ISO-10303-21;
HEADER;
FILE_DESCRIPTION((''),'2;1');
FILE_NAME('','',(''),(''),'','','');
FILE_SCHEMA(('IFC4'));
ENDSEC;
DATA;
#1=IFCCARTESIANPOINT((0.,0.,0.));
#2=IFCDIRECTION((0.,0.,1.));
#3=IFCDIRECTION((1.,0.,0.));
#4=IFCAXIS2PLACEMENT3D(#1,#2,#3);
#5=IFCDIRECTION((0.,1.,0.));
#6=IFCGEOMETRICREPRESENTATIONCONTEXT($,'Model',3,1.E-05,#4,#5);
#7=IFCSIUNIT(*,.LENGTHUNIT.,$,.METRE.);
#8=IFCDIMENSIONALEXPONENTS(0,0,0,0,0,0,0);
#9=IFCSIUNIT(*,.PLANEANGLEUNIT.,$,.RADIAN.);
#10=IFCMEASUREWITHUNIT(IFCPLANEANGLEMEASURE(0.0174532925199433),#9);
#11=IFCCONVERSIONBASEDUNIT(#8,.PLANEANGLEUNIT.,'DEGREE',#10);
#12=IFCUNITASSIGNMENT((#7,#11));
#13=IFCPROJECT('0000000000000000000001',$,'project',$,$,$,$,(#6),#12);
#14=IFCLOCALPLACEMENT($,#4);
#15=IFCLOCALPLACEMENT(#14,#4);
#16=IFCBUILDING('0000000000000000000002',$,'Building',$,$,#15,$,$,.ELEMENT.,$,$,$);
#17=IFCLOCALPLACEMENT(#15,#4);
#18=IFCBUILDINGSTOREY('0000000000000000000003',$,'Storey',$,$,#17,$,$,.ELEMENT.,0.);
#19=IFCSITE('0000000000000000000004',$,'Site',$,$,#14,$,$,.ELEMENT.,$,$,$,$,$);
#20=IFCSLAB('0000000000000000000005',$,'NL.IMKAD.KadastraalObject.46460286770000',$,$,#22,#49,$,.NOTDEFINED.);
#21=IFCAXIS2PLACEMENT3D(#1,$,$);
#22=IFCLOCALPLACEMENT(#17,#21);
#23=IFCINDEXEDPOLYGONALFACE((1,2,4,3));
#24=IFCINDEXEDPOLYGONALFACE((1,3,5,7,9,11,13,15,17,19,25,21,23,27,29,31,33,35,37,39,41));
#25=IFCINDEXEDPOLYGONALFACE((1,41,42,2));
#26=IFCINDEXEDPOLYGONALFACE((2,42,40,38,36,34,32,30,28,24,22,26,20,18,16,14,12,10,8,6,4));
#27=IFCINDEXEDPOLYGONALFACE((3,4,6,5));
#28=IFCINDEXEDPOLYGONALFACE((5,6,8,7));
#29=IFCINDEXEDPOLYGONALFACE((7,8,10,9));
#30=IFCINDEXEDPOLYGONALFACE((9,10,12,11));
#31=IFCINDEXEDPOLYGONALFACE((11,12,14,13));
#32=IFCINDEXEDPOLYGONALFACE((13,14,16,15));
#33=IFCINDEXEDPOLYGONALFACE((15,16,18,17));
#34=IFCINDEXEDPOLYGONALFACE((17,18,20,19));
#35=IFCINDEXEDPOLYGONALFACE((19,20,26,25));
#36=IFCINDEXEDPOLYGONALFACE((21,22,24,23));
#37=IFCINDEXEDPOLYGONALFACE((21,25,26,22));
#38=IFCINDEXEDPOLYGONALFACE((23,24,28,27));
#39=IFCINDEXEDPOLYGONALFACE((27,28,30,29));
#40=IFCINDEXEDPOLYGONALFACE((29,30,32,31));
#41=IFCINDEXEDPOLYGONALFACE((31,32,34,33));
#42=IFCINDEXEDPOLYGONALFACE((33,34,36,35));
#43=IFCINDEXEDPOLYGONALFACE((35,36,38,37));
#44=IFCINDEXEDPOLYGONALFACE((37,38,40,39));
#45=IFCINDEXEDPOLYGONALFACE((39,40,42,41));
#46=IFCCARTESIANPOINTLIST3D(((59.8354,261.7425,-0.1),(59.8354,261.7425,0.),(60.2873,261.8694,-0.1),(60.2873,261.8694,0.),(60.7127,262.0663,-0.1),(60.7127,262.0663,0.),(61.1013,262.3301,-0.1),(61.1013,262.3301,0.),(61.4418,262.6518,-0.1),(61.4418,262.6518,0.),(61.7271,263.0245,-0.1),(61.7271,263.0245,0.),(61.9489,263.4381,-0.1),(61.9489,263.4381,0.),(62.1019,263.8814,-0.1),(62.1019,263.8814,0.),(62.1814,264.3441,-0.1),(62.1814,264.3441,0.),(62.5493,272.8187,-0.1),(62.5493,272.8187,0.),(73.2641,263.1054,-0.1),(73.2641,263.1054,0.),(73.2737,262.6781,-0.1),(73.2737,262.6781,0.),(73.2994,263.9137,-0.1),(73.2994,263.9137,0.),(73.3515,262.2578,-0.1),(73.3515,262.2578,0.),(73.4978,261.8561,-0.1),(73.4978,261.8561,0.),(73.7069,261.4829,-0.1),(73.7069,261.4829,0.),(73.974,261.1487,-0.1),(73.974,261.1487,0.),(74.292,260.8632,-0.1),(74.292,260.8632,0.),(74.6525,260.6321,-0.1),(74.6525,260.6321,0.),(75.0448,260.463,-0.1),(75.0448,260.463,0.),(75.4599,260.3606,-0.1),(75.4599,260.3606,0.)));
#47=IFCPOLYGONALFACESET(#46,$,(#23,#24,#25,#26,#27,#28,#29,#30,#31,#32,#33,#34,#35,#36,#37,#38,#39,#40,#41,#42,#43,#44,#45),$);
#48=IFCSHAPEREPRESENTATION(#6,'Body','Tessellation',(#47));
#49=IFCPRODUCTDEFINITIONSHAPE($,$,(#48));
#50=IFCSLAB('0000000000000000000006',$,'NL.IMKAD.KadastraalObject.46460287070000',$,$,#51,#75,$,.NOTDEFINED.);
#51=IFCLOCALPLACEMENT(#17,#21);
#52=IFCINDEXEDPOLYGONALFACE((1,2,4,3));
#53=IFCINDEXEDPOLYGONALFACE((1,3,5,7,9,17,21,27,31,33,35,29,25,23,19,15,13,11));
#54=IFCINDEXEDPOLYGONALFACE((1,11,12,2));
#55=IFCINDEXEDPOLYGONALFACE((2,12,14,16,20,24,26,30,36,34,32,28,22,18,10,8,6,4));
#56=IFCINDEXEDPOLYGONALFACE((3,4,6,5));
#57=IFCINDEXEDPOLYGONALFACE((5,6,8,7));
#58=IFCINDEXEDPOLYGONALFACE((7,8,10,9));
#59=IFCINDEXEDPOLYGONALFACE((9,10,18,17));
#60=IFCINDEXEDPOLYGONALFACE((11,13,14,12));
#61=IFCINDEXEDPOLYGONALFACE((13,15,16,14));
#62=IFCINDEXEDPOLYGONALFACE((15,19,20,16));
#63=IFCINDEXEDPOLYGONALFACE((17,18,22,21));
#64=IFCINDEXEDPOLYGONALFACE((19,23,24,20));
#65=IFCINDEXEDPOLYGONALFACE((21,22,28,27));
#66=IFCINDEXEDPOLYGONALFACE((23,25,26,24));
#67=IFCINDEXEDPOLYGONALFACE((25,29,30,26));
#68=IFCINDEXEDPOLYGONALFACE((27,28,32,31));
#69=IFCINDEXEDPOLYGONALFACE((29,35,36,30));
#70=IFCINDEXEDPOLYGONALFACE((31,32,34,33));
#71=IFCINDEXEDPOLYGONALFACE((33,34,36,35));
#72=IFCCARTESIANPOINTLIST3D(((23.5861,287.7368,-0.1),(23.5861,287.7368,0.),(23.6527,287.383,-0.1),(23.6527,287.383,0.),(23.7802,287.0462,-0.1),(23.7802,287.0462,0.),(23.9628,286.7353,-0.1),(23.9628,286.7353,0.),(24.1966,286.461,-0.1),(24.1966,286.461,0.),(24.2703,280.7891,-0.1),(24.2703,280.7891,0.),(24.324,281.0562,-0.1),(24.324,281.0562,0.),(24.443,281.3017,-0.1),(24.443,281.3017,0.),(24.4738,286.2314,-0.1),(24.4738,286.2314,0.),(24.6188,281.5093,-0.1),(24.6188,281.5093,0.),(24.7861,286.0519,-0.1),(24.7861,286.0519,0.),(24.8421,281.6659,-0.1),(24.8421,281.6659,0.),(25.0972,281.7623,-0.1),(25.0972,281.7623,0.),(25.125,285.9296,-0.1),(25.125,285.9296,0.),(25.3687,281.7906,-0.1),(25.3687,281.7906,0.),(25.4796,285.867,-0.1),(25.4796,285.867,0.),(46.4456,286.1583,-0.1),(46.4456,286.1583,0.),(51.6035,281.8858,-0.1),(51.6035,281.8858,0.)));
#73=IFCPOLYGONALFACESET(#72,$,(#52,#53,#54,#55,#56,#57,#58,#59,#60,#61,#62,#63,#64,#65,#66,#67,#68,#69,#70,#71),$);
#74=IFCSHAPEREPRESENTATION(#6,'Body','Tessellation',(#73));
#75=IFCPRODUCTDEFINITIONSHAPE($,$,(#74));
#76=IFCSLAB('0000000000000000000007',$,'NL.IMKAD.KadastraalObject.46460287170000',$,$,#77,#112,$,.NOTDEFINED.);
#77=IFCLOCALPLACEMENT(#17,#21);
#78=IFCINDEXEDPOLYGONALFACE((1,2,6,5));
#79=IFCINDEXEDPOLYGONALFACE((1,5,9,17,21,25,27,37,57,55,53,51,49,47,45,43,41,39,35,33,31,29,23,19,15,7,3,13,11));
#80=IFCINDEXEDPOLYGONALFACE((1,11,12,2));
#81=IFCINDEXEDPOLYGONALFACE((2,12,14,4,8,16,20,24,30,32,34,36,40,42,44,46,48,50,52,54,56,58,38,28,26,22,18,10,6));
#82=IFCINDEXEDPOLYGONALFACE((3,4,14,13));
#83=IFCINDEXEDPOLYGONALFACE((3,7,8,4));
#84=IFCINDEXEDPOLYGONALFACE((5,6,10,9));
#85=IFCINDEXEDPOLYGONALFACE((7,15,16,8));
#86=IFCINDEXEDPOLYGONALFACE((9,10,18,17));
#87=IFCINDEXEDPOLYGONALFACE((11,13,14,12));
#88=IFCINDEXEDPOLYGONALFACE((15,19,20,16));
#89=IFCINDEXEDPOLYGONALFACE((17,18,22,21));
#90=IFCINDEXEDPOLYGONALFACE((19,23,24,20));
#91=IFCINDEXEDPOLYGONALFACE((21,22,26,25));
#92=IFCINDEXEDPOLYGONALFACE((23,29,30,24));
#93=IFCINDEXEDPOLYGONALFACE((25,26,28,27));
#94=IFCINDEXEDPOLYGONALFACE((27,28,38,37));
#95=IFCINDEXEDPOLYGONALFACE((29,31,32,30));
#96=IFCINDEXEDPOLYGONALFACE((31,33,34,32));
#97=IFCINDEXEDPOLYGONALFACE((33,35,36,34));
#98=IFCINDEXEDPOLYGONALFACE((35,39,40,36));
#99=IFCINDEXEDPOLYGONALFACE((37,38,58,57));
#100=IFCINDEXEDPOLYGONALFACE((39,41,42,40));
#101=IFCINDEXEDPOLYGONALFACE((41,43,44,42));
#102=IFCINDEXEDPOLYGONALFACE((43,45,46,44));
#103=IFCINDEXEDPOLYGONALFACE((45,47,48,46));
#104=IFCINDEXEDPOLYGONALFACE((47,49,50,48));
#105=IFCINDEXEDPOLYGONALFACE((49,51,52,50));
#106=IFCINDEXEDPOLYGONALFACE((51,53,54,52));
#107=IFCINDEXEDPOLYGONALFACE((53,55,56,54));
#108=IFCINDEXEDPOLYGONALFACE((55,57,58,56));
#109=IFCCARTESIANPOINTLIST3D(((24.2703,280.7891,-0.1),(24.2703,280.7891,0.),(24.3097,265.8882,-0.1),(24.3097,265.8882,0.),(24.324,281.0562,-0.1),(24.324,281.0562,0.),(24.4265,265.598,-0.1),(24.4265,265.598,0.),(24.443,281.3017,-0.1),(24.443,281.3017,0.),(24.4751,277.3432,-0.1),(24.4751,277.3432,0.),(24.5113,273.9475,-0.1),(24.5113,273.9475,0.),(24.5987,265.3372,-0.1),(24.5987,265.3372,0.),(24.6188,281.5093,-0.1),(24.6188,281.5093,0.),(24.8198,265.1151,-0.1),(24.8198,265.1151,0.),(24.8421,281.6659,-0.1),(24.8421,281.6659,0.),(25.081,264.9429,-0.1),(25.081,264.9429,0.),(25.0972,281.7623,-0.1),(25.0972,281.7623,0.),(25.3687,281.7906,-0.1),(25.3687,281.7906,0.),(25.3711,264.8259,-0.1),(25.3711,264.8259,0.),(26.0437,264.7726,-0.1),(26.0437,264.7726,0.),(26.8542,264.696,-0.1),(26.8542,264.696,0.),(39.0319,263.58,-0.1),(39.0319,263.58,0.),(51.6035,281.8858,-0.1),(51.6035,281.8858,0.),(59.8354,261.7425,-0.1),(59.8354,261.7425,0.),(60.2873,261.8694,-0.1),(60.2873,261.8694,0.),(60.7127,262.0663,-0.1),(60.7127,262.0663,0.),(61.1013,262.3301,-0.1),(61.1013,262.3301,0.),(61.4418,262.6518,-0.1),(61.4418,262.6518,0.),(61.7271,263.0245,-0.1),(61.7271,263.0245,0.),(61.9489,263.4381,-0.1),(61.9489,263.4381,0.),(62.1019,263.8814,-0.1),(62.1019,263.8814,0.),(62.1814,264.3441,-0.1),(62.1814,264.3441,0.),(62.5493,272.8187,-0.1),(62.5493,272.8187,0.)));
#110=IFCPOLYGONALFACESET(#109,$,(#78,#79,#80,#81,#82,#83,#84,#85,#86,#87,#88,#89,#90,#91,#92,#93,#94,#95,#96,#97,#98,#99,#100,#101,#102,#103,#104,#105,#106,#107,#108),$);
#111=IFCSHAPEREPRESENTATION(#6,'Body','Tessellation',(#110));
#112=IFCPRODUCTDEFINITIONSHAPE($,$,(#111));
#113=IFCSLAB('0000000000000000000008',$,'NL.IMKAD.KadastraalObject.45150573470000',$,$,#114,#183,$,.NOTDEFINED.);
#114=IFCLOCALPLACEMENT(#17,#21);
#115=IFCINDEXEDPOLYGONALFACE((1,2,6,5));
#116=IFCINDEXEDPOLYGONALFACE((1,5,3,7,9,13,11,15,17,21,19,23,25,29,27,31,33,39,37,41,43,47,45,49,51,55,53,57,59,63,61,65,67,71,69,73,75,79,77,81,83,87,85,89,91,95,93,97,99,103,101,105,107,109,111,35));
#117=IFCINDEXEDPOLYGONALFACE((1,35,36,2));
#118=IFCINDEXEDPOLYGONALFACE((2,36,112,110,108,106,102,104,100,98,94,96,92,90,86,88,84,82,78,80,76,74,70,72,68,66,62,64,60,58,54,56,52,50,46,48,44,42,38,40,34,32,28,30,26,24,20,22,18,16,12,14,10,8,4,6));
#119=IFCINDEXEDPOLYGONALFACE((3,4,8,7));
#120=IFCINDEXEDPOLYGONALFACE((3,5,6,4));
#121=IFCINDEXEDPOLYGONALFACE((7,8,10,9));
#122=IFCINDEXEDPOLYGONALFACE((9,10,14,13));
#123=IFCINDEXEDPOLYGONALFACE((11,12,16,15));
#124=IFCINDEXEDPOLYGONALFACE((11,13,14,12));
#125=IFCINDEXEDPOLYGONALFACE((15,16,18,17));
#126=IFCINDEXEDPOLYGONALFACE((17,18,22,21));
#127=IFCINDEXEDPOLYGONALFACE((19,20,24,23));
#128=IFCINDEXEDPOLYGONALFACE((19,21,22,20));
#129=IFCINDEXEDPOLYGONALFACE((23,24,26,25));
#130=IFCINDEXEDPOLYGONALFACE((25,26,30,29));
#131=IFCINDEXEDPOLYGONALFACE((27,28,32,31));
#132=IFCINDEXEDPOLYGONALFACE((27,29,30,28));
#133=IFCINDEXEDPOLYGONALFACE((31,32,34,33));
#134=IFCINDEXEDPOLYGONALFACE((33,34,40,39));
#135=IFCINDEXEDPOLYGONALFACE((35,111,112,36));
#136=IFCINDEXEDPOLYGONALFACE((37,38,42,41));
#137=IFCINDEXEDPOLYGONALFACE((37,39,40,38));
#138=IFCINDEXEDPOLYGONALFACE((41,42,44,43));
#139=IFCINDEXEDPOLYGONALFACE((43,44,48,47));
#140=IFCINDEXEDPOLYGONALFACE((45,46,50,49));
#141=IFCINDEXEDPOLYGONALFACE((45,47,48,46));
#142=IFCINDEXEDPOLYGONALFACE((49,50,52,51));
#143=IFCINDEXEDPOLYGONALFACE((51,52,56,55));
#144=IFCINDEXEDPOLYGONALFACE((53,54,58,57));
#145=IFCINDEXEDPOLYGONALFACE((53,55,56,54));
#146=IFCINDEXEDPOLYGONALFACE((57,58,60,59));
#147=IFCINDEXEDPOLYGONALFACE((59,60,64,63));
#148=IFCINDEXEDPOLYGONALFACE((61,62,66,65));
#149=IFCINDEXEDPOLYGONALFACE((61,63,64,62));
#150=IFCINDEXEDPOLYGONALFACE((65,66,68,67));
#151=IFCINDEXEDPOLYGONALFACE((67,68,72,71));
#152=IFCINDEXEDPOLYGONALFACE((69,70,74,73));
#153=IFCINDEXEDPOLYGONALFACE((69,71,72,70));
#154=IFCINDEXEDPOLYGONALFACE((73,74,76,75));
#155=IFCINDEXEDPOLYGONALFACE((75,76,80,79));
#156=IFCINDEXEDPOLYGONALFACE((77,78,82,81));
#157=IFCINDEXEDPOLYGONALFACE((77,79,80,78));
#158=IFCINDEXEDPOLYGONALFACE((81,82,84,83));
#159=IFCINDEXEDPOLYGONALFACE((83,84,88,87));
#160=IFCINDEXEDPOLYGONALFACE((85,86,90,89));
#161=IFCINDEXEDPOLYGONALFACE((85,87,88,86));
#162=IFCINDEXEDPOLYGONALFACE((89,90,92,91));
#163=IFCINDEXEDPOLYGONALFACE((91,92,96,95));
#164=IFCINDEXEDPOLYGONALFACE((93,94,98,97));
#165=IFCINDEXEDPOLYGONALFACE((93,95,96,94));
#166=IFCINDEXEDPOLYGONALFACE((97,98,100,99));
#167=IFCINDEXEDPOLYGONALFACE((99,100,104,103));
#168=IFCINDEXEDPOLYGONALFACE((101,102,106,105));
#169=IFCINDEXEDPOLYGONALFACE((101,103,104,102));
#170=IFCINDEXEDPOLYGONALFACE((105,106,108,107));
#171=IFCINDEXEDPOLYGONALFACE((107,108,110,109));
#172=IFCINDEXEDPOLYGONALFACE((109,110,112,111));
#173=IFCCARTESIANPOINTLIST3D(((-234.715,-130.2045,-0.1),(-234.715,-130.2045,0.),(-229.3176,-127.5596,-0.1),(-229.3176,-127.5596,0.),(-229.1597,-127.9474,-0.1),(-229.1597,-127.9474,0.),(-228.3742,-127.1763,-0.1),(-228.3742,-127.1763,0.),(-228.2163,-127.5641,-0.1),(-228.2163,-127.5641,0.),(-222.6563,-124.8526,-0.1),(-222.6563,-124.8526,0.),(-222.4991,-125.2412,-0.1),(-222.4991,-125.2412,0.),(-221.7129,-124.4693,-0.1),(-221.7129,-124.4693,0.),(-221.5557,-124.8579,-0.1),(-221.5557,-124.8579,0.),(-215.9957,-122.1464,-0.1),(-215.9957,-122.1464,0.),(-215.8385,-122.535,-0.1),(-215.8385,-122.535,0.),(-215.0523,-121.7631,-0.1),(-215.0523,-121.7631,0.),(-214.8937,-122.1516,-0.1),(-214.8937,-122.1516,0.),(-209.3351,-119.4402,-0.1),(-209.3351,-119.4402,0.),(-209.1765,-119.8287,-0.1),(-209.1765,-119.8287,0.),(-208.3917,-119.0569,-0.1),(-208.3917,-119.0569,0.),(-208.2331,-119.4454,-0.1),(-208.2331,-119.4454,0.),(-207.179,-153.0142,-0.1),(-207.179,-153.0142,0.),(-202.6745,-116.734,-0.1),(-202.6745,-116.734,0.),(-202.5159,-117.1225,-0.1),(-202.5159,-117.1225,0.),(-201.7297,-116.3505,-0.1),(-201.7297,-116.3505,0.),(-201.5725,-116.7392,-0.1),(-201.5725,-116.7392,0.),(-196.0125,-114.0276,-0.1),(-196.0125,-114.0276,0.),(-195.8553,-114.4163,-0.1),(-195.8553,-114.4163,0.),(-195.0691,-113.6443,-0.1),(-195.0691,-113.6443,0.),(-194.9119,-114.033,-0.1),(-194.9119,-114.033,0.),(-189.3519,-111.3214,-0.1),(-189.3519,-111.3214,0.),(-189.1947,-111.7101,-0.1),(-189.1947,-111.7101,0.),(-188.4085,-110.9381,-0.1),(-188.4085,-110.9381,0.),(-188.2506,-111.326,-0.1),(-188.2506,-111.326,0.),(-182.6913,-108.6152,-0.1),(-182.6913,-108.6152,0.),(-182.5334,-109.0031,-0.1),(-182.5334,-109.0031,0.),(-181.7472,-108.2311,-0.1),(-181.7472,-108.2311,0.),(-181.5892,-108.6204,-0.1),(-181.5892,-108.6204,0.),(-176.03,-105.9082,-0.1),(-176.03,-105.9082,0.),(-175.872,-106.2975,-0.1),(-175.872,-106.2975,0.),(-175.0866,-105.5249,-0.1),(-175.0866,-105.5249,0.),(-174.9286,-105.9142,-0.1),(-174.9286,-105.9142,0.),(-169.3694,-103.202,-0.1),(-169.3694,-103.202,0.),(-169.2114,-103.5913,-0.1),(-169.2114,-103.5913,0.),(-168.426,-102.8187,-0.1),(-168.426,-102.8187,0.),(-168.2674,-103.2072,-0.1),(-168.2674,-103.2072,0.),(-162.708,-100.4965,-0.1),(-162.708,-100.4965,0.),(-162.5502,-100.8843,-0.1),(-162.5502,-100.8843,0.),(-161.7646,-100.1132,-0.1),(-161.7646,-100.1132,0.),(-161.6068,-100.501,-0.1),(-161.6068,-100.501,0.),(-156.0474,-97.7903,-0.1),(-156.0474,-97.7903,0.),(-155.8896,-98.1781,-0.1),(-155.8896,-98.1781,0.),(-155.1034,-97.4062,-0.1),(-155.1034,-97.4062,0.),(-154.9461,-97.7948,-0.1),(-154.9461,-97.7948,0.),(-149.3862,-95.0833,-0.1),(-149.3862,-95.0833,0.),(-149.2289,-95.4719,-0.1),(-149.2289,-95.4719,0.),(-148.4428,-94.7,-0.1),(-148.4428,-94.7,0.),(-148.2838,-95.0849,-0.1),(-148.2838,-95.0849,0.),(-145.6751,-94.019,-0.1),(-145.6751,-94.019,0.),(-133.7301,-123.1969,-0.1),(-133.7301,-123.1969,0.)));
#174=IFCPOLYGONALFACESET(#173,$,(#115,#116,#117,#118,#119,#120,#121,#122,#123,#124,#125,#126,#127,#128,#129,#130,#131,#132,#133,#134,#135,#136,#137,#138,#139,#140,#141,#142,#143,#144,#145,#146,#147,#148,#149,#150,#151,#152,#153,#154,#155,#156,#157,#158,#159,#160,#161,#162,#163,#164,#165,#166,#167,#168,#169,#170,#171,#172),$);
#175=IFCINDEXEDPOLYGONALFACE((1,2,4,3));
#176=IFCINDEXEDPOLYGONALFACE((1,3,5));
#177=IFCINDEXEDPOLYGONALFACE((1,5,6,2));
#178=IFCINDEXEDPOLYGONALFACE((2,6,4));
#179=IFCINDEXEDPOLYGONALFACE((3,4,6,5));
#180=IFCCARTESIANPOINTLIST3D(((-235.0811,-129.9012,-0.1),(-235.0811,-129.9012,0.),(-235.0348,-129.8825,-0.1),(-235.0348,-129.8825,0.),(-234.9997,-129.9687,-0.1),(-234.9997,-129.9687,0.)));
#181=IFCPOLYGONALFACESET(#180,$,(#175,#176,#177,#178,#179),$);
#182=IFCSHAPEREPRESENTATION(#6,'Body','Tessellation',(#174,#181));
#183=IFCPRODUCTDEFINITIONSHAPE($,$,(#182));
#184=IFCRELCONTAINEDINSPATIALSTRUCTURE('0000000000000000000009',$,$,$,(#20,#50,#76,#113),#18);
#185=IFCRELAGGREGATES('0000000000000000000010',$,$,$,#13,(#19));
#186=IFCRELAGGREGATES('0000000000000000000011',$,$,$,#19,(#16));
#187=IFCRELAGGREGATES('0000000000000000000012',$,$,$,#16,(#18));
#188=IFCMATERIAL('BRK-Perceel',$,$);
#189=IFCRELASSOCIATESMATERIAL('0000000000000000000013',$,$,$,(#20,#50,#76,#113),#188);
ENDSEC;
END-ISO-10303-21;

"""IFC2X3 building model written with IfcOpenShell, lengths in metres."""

from ifc_helpers import new_model, entity, si_unit, converted_unit, direction, frame, origin_with_axes, place, context, project, spatial, polyline, outline, extrude, material, element, save


model = new_model("IFC2X3")

# Units and contexts
model_context = context("Model", 3, precision=1e-05, world=origin_with_axes(), true_north=direction((0.0, 1.0, 0.0)))
ifc_project = project(units=[si_unit("LENGTHUNIT", "METRE"), converted_unit("PLANEANGLEUNIT", "DEGREE", entity("IfcPlaneAngleMeasure", 0.0174532925199433), si_unit("PLANEANGLEUNIT", "RADIAN"), dimensions=[0, 0, 0, 0, 0, 0, 0])], contexts=[model_context])

# Site, building, storey
site_placement = place(None, origin_with_axes())
site = spatial("IfcSite", under=ifc_project, at=site_placement, Name="Site", CompositionType="ELEMENT")
building_placement = place(site_placement, origin_with_axes())
building = spatial("IfcBuilding", under=site, at=building_placement, Name="Building", CompositionType="ELEMENT")
storey_placement = place(building_placement, origin_with_axes())
storey = spatial("IfcBuildingStorey", under=building, at=storey_placement, Name="Storey", CompositionType="ELEMENT", Elevation=0.0)

# Slabs
ifc_material = material(Name="BRK-Perceel")
slab_1_placement = place(storey_placement, frame((0.0, 0.0, -0.1), z_axis=(0.0, 0.0, 1.0), x_axis=(1.0, 0.0, 0.0)))
element("IfcSlab", 1, at=slab_1_placement, inside=storey, material=ifc_material, Name="NL.IMKAD.KadastraalObject.46460286770000", PredefinedType="NOTDEFINED", context=model_context, shape_type="SweptSolid", body=[
    extrude(outline(polyline([(73.2641, 263.1054), (73.2737, 262.6781), (73.3515, 262.2578), (73.4978, 261.8561), (73.7069, 261.4829), (73.974, 261.1487), (74.292, 260.8632), (74.6525, 260.6321), (75.0448, 260.463), (75.4599, 260.3606), (59.8354, 261.7425), (60.2873, 261.8694), (60.7127, 262.0663), (61.1013, 262.3301), (61.4418, 262.6518), (61.7271, 263.0245), (61.9489, 263.4381), (62.1019, 263.8814), (62.1814, 264.3441), (62.5493, 272.8187), (73.2994, 263.9137), (73.2641, 263.1054)])), origin_with_axes(), (0.0, 0.0, 1.0), 0.1),
])
slab_2_placement = place(storey_placement, frame((0.0, 0.0, -0.1), z_axis=(0.0, 0.0, 1.0), x_axis=(1.0, 0.0, 0.0)))
element("IfcSlab", 2, at=slab_2_placement, inside=storey, material=ifc_material, Name="NL.IMKAD.KadastraalObject.46460287070000", PredefinedType="NOTDEFINED", context=model_context, shape_type="SweptSolid", body=[
    extrude(outline(polyline([(25.3687, 281.7906), (25.0972, 281.7623), (24.8421, 281.6659), (24.6188, 281.5093), (24.443, 281.3017), (24.324, 281.0562), (24.2703, 280.7891), (23.5861, 287.7368), (23.6527, 287.383), (23.7802, 287.0462), (23.9628, 286.7353), (24.1966, 286.461), (24.4738, 286.2314), (24.7861, 286.0519), (25.125, 285.9296), (25.4796, 285.867), (46.4456, 286.1583), (51.6035, 281.8858), (25.3687, 281.7906)])), origin_with_axes(), (0.0, 0.0, 1.0), 0.1),
])
slab_3_placement = place(storey_placement, frame((0.0, 0.0, -0.1), z_axis=(0.0, 0.0, 1.0), x_axis=(1.0, 0.0, 0.0)))
element("IfcSlab", 3, at=slab_3_placement, inside=storey, material=ifc_material, Name="NL.IMKAD.KadastraalObject.46460287170000", PredefinedType="NOTDEFINED", context=model_context, shape_type="SweptSolid", body=[
    extrude(outline(polyline([(62.1814, 264.3441), (62.1019, 263.8814), (61.9489, 263.4381), (61.7271, 263.0245), (61.4418, 262.6518), (61.1013, 262.3301), (60.7127, 262.0663), (60.2873, 261.8694), (59.8354, 261.7425), (39.0319, 263.58), (26.8542, 264.696), (26.0437, 264.7726), (25.3711, 264.8259), (25.081, 264.9429), (24.8198, 265.1151), (24.5987, 265.3372), (24.4265, 265.598), (24.3097, 265.8882), (24.5113, 273.9475), (24.4751, 277.3432), (24.2703, 280.7891), (24.324, 281.0562), (24.443, 281.3017), (24.6188, 281.5093), (24.8421, 281.6659), (25.0972, 281.7623), (25.3687, 281.7906), (51.6035, 281.8858), (62.5493, 272.8187), (62.1814, 264.3441)])), origin_with_axes(), (0.0, 0.0, 1.0), 0.1),
])
slab_4_placement = place(storey_placement, frame((0.0, 0.0, -0.1), z_axis=(0.0, 0.0, 1.0), x_axis=(1.0, 0.0, 0.0)))
element("IfcSlab", 4, at=slab_4_placement, inside=storey, material=ifc_material, Name="NL.IMKAD.KadastraalObject.45150573470000", PredefinedType="NOTDEFINED", context=model_context, shape_type="SweptSolid", body=[
    extrude(outline(polyline([(-229.1597, -127.9474), (-229.3176, -127.5596), (-228.3742, -127.1763), (-228.2163, -127.5641), (-222.4991, -125.2412), (-222.6563, -124.8526), (-221.7129, -124.4693), (-221.5557, -124.8579), (-215.8385, -122.535), (-215.9957, -122.1464), (-215.0523, -121.7631), (-214.8937, -122.1516), (-209.1765, -119.8287), (-209.3351, -119.4402), (-208.3917, -119.0569), (-208.2331, -119.4454), (-202.5159, -117.1225), (-202.6745, -116.734), (-201.7297, -116.3505), (-201.5725, -116.7392), (-195.8553, -114.4163), (-196.0125, -114.0276), (-195.0691, -113.6443), (-194.9119, -114.033), (-189.1947, -111.7101), (-189.3519, -111.3214), (-188.4085, -110.9381), (-188.2506, -111.326), (-182.5334, -109.0031), (-182.6913, -108.6152), (-181.7472, -108.2311), (-181.5892, -108.6204), (-175.872, -106.2975), (-176.03, -105.9082), (-175.0866, -105.5249), (-174.9286, -105.9142), (-169.2114, -103.5913), (-169.3694, -103.202), (-168.426, -102.8187), (-168.2674, -103.2072), (-162.5502, -100.8843), (-162.708, -100.4965), (-161.7646, -100.1132), (-161.6068, -100.501), (-155.8896, -98.1781), (-156.0474, -97.7903), (-155.1034, -97.4062), (-154.9461, -97.7948), (-149.2289, -95.4719), (-149.3862, -95.0833), (-148.4428, -94.7), (-148.2838, -95.0849), (-145.6751, -94.019), (-133.7301, -123.1969), (-207.179, -153.0142), (-234.715, -130.2045), (-229.1597, -127.9474)])), origin_with_axes(), (0.0, 0.0, 1.0), 0.1),
    extrude(outline(polyline([(-235.0348, -129.8825), (-234.9997, -129.9687), (-235.0811, -129.9012), (-235.0348, -129.8825)])), origin_with_axes(), (0.0, 0.0, 1.0), 0.1),
])

save(model, "model.ifc")
